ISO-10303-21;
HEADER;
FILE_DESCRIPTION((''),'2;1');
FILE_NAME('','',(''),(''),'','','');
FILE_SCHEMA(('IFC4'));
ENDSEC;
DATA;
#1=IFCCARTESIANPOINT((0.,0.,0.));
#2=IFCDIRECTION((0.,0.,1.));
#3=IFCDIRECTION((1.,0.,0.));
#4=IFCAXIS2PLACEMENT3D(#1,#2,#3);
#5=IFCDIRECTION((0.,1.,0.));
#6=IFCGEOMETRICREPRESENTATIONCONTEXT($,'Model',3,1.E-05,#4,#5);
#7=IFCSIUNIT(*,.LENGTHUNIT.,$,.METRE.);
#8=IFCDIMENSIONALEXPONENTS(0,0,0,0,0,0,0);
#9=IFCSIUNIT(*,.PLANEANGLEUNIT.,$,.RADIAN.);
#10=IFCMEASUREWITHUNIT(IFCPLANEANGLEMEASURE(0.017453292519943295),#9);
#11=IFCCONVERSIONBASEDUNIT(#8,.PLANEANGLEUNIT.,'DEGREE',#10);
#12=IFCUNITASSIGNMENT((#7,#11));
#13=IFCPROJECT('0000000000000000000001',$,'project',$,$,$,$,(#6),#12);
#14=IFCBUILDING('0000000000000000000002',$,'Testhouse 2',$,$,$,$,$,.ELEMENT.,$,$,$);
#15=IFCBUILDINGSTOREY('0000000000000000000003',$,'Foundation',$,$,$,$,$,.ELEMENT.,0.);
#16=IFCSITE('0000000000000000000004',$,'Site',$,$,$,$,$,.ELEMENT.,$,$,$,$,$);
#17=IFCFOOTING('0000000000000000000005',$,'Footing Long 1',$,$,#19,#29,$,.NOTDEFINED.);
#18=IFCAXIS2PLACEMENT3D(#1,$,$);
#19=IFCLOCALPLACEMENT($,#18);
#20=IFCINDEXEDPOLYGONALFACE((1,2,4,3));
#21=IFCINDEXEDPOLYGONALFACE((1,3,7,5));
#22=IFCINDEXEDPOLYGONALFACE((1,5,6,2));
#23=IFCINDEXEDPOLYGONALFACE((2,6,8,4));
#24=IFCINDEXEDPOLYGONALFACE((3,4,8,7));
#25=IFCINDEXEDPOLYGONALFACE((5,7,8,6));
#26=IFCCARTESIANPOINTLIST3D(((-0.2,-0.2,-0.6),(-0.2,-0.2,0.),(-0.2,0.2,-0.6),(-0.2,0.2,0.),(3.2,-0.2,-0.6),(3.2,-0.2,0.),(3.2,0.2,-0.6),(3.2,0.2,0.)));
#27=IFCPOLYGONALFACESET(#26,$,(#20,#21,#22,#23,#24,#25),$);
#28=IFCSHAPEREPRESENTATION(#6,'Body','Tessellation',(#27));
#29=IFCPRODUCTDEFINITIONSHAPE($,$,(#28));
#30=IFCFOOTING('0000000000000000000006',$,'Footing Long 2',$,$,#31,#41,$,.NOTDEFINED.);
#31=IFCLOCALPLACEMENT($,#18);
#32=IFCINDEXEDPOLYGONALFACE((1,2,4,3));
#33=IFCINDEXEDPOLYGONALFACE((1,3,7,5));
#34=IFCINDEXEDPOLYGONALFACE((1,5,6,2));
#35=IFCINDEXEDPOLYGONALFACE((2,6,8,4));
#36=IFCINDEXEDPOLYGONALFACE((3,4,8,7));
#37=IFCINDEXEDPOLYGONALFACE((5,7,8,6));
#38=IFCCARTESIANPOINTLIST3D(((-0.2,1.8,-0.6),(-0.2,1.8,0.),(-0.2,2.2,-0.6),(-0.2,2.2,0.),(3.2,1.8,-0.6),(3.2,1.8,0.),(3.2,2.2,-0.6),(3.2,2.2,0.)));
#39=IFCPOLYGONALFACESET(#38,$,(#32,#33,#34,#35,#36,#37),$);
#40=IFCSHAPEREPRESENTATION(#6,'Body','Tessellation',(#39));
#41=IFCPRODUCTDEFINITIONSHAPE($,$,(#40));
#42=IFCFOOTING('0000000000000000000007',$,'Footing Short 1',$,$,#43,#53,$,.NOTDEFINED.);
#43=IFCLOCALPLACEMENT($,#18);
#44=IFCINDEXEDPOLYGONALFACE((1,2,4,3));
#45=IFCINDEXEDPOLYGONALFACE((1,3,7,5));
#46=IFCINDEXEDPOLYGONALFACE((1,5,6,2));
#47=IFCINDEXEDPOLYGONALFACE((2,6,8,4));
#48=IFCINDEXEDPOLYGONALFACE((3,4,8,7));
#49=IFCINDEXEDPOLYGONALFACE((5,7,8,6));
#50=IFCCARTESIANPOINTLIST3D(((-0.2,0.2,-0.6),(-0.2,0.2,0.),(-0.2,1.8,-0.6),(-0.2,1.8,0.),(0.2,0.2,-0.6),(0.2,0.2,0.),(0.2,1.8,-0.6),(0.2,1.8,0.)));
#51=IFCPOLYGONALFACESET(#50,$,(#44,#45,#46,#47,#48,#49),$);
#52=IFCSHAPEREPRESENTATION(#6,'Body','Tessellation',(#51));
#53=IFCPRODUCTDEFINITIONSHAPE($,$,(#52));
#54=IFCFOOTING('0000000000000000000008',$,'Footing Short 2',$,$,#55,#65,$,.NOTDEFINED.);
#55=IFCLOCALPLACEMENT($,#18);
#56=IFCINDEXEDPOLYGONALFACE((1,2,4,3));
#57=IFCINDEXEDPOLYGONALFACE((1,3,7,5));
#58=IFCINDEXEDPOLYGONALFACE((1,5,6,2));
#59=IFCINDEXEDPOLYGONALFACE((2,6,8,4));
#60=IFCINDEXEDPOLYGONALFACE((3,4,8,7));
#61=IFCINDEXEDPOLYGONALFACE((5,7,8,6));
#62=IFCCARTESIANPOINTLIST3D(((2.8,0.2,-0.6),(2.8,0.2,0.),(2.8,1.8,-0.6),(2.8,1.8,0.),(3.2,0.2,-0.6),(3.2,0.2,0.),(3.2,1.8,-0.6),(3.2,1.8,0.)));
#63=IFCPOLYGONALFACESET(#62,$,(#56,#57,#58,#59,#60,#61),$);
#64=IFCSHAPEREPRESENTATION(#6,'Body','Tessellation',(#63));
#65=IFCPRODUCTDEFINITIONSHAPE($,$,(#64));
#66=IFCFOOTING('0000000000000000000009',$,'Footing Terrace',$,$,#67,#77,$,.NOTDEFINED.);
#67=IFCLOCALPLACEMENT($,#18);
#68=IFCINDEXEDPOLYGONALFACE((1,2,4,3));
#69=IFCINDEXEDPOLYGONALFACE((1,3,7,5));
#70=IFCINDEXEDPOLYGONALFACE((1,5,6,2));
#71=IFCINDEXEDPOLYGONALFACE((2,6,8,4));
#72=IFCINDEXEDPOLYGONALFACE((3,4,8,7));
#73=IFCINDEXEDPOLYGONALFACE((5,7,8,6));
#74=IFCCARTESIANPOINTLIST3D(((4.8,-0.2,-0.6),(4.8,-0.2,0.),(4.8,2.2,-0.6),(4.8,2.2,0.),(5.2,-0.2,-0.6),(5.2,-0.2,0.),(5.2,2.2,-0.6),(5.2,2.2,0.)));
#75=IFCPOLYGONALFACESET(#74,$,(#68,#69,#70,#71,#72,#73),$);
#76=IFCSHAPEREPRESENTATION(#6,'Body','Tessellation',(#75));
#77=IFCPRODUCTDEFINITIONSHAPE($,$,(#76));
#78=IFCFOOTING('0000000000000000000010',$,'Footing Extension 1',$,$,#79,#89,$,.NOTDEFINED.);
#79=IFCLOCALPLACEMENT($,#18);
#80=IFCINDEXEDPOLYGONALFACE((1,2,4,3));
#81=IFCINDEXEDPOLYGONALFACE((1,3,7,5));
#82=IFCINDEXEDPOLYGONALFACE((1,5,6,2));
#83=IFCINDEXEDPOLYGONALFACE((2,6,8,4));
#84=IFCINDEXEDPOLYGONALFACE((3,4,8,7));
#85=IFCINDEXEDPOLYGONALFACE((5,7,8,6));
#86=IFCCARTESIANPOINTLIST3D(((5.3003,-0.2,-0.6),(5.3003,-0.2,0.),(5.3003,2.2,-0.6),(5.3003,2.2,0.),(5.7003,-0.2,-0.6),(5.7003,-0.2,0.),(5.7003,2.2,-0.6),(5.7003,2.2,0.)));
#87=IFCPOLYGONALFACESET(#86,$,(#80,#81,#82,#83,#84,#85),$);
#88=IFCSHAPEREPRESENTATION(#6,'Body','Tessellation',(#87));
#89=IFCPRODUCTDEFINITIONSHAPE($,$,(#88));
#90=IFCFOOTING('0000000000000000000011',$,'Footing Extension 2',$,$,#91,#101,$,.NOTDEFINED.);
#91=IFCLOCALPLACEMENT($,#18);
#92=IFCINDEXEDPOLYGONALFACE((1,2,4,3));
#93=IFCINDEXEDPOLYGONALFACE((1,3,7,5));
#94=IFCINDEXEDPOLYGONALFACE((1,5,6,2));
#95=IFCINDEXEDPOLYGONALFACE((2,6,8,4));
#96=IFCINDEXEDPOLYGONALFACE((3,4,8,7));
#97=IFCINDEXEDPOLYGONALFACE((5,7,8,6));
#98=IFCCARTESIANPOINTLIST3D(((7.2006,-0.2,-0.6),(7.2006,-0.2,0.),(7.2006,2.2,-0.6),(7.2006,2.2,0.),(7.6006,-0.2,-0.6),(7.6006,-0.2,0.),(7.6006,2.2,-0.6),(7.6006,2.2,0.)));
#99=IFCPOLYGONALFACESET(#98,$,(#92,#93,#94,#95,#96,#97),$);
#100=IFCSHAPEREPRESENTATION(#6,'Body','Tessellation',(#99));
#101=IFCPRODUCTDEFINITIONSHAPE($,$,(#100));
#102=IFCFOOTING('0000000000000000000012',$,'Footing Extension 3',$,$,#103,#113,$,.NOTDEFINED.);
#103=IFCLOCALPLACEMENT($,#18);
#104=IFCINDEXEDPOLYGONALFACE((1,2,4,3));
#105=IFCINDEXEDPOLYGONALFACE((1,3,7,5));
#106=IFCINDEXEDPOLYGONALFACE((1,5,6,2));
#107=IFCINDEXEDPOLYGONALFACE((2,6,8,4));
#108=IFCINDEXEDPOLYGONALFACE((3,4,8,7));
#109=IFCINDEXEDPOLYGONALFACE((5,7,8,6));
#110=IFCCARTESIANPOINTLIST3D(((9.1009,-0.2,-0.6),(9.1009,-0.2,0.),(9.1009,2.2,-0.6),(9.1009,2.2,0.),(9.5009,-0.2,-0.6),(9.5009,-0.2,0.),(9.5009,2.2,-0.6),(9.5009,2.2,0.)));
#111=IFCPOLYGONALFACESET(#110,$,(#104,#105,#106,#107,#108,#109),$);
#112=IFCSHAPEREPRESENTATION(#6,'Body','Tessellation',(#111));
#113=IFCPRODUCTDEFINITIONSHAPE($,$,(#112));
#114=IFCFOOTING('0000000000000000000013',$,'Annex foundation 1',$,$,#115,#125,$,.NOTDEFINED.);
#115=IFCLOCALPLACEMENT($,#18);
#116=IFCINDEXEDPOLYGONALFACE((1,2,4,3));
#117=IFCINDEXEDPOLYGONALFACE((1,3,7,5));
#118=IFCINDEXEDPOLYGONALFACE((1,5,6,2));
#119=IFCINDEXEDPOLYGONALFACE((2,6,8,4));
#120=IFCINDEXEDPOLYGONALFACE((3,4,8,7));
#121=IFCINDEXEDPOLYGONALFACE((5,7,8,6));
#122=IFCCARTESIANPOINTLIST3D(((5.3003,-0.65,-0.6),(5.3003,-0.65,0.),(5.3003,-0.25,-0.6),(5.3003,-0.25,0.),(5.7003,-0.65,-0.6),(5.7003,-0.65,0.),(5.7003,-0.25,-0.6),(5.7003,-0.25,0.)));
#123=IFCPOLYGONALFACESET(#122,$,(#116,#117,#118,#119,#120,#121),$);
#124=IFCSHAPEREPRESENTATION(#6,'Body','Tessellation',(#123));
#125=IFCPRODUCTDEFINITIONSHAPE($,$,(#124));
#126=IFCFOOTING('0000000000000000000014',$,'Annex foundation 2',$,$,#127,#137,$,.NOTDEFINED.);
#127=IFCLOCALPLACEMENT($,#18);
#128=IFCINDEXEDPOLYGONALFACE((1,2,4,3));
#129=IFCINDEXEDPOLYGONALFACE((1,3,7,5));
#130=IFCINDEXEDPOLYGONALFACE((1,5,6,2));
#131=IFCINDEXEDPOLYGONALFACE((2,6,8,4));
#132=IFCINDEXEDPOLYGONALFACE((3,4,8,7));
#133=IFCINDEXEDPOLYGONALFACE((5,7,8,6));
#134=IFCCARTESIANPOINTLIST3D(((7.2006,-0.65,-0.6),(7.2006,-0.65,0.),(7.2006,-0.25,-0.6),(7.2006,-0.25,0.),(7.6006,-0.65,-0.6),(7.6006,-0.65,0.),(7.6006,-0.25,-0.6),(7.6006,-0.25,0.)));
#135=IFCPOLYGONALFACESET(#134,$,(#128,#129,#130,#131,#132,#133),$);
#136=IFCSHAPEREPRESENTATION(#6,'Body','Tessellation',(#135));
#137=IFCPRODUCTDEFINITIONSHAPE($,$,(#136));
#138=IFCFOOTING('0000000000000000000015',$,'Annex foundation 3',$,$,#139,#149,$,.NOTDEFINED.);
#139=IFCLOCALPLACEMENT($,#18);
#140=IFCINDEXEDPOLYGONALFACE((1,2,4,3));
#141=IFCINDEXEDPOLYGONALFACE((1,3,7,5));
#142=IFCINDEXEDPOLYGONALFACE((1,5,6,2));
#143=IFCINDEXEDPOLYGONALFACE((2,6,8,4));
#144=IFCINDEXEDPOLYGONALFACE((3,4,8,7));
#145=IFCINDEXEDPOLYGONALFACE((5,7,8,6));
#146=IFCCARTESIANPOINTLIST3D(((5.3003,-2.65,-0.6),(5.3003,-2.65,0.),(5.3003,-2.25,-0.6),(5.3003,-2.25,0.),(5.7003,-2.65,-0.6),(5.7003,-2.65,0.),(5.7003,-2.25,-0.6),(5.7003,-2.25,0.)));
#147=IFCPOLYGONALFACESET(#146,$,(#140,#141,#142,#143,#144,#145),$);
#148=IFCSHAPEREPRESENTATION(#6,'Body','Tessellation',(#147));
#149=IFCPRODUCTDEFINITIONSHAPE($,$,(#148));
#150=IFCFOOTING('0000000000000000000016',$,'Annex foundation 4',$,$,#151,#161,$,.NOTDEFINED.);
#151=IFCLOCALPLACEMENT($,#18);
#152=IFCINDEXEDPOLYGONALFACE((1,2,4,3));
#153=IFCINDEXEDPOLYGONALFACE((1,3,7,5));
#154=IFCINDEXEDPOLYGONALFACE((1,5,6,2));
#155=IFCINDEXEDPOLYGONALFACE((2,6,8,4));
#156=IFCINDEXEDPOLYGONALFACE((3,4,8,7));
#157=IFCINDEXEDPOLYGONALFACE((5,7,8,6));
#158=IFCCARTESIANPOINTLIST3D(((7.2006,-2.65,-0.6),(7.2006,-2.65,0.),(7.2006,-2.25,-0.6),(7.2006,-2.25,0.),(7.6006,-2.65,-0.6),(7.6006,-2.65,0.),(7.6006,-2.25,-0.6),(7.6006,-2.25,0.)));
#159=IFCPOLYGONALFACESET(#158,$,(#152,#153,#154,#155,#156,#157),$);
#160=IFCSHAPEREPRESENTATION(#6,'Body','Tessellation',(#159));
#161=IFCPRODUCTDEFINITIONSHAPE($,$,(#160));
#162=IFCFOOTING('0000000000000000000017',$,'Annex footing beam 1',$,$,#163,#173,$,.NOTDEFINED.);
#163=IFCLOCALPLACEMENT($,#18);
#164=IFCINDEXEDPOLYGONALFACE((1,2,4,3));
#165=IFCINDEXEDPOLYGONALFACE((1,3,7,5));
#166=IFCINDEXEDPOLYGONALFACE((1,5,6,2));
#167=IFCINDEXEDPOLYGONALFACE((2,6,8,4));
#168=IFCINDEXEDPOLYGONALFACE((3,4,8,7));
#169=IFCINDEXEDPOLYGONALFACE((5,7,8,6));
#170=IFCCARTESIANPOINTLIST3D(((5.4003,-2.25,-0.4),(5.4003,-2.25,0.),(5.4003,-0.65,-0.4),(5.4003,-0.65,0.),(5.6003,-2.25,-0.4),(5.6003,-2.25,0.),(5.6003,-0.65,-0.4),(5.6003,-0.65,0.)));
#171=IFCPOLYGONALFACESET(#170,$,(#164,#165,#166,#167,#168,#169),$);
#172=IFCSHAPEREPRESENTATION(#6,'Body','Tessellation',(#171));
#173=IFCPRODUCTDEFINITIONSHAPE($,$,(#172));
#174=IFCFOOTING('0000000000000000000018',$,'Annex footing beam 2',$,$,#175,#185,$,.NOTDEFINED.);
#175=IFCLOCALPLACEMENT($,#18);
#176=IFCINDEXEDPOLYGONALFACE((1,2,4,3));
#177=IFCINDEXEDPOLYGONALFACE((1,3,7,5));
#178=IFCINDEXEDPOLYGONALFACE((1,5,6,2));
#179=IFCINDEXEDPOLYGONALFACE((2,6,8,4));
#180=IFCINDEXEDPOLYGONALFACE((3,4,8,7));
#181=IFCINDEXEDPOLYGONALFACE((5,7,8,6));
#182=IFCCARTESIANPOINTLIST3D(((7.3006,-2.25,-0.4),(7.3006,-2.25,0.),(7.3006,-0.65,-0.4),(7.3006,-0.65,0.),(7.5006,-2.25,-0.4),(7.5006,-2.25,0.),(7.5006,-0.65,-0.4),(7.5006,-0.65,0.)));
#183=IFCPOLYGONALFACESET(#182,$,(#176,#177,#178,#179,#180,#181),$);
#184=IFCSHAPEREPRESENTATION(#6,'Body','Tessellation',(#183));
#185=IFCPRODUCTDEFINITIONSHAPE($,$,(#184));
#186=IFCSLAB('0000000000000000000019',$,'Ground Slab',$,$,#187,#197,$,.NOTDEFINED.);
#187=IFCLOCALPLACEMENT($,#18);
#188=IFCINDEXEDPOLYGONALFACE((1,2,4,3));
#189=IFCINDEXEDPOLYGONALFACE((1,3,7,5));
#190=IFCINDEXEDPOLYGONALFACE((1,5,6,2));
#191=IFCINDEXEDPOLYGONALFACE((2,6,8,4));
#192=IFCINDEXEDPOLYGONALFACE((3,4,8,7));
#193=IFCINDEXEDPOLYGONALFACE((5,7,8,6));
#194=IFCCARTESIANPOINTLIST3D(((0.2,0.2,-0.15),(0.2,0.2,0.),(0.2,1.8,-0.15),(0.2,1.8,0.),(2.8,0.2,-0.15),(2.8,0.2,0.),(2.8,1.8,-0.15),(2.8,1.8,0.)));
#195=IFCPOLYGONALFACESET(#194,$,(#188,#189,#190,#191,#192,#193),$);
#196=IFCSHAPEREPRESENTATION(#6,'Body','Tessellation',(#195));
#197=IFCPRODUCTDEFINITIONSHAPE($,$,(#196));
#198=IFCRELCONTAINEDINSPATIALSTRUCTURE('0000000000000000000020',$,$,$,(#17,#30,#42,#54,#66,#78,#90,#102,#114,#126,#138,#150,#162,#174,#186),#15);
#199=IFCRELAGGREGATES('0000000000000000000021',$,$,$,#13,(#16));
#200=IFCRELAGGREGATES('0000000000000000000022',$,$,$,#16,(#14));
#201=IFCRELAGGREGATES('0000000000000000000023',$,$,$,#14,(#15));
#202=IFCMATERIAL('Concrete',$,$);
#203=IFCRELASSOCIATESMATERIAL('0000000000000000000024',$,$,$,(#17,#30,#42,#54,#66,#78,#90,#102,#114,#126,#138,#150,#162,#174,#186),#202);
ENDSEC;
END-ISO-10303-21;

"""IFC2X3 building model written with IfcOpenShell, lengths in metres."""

from ifc_helpers import new_model, entity, si_unit, converted_unit, direction, frame, origin_with_axes, place, context, project, spatial, polyline, outline, extrude, material, element, save


model = new_model("IFC2X3")

# Units and contexts
model_context = context("Model", 3, precision=1e-05, world=origin_with_axes(), true_north=direction((0.0, 1.0, 0.0)))
ifc_project = project(units=[si_unit("LENGTHUNIT", "METRE"), converted_unit("PLANEANGLEUNIT", "DEGREE", entity("IfcPlaneAngleMeasure", 0.017453292519943295), si_unit("PLANEANGLEUNIT", "RADIAN"), dimensions=[0, 0, 0, 0, 0, 0, 0])], contexts=[model_context])

# Site, building, storey
site = spatial("IfcSite", under=ifc_project, Name="Site", CompositionType="ELEMENT")
building = spatial("IfcBuilding", under=site, Name="Testhouse 2", CompositionType="ELEMENT")
storey = spatial("IfcBuildingStorey", under=building, Name="Foundation", CompositionType="ELEMENT", Elevation=0.0)

# Footings
ifc_material = material(Name="Concrete")
footing_1_placement = place(None, origin_with_axes())
element("IfcFooting", 1, at=footing_1_placement, inside=storey, material=ifc_material, Name="Footing Long 1", PredefinedType="NOTDEFINED", context=model_context, shape_type="SweptSolid", body=[
    extrude(outline(polyline([(-0.3, -0.2), (0.3, -0.2), (0.3, 0.2), (-0.3, 0.2), (-0.3, -0.2)])), frame((-0.2, 0.0, -0.3), z_axis=(1.0, 0.0, 0.0), x_axis=(0.0, 0.0, -1.0)), (0.0, 0.0, 1.0), 3.4),
])
footing_2_placement = place(None, origin_with_axes())
element("IfcFooting", 2, at=footing_2_placement, inside=storey, material=ifc_material, Name="Footing Long 2", PredefinedType="NOTDEFINED", context=model_context, shape_type="SweptSolid", body=[
    extrude(outline(polyline([(-0.3, -0.2), (0.3, -0.2), (0.3, 0.2), (-0.3, 0.2), (-0.3, -0.2)])), frame((-0.2, 2.0, -0.3), z_axis=(1.0, 0.0, 0.0), x_axis=(0.0, 0.0, -1.0)), (0.0, 0.0, 1.0), 3.4),
])
footing_3_placement = place(None, origin_with_axes())
element("IfcFooting", 3, at=footing_3_placement, inside=storey, material=ifc_material, Name="Footing Short 1", PredefinedType="NOTDEFINED", context=model_context, shape_type="SweptSolid", body=[
    extrude(outline(polyline([(-0.3, -0.2), (0.3, -0.2), (0.3, 0.2), (-0.3, 0.2), (-0.3, -0.2)])), frame((0.0, 0.2, -0.3), z_axis=(0.0, 1.0, 0.0), x_axis=(0.0, 0.0, -1.0)), (0.0, 0.0, 1.0), 1.6),
])
footing_4_placement = place(None, origin_with_axes())
element("IfcFooting", 4, at=footing_4_placement, inside=storey, material=ifc_material, Name="Footing Short 2", PredefinedType="NOTDEFINED", context=model_context, shape_type="SweptSolid", body=[
    extrude(outline(polyline([(-0.3, -0.2), (0.3, -0.2), (0.3, 0.2), (-0.3, 0.2), (-0.3, -0.2)])), frame((3.0, 0.2, -0.3), z_axis=(0.0, 1.0, 0.0), x_axis=(0.0, 0.0, -1.0)), (0.0, 0.0, 1.0), 1.6),
])
footing_5_placement = place(None, origin_with_axes())
element("IfcFooting", 5, at=footing_5_placement, inside=storey, material=ifc_material, Name="Footing Terrace", PredefinedType="NOTDEFINED", context=model_context, shape_type="SweptSolid", body=[
    extrude(outline(polyline([(-0.3, -0.2), (0.3, -0.2), (0.3, 0.2), (-0.3, 0.2), (-0.3, -0.2)])), frame((5.0, -0.2, -0.3), z_axis=(0.0, 1.0, 0.0), x_axis=(0.0, 0.0, -1.0)), (0.0, 0.0, 1.0), 2.4),
])
footing_6_placement = place(None, origin_with_axes())
element("IfcFooting", 6, at=footing_6_placement, inside=storey, material=ifc_material, Name="Footing Extension 1", PredefinedType="NOTDEFINED", context=model_context, shape_type="SweptSolid", body=[
    extrude(outline(polyline([(-0.3, -0.2), (0.3, -0.2), (0.3, 0.2), (-0.3, 0.2), (-0.3, -0.2)])), frame((5.5003, -0.2, -0.3), z_axis=(0.0, 1.0, 0.0), x_axis=(0.0, 0.0, -1.0)), (0.0, 0.0, 1.0), 2.4),
])
footing_7_placement = place(None, origin_with_axes())
element("IfcFooting", 7, at=footing_7_placement, inside=storey, material=ifc_material, Name="Footing Extension 2", PredefinedType="NOTDEFINED", context=model_context, shape_type="SweptSolid", body=[
    extrude(outline(polyline([(-0.3, -0.2), (0.3, -0.2), (0.3, 0.2), (-0.3, 0.2), (-0.3, -0.2)])), frame((7.4006, -0.2, -0.3), z_axis=(0.0, 1.0, 0.0), x_axis=(0.0, 0.0, -1.0)), (0.0, 0.0, 1.0), 2.4),
])
footing_8_placement = place(None, origin_with_axes())
element("IfcFooting", 8, at=footing_8_placement, inside=storey, material=ifc_material, Name="Footing Extension 3", PredefinedType="NOTDEFINED", context=model_context, shape_type="SweptSolid", body=[
    extrude(outline(polyline([(-0.3, -0.2), (0.3, -0.2), (0.3, 0.2), (-0.3, 0.2), (-0.3, -0.2)])), frame((9.3009, -0.2, -0.3), z_axis=(0.0, 1.0, 0.0), x_axis=(0.0, 0.0, -1.0)), (0.0, 0.0, 1.0), 2.4),
])
footing_9_placement = place(None, origin_with_axes())
element("IfcFooting", 9, at=footing_9_placement, inside=storey, material=ifc_material, Name="Annex foundation 1", PredefinedType="NOTDEFINED", context=model_context, shape_type="SweptSolid", body=[
    extrude(outline(polyline([(-0.2, -0.2), (0.2, -0.2), (0.2, 0.2), (-0.2, 0.2), (-0.2, -0.2)])), frame((5.5003, -0.45, -0.6), z_axis=(0.0, 0.0, 1.0), x_axis=(1.0, 0.0, 0.0)), (0.0, 0.0, 1.0), 0.6),
])
footing_10_placement = place(None, origin_with_axes())
element("IfcFooting", 10, at=footing_10_placement, inside=storey, material=ifc_material, Name="Annex foundation 2", PredefinedType="NOTDEFINED", context=model_context, shape_type="SweptSolid", body=[
    extrude(outline(polyline([(-0.2, -0.2), (0.2, -0.2), (0.2, 0.2), (-0.2, 0.2), (-0.2, -0.2)])), frame((7.4006, -0.45, -0.6), z_axis=(0.0, 0.0, 1.0), x_axis=(1.0, 0.0, 0.0)), (0.0, 0.0, 1.0), 0.6),
])
footing_11_placement = place(None, origin_with_axes())
element("IfcFooting", 11, at=footing_11_placement, inside=storey, material=ifc_material, Name="Annex foundation 3", PredefinedType="NOTDEFINED", context=model_context, shape_type="SweptSolid", body=[
    extrude(outline(polyline([(-0.2, -0.2), (0.2, -0.2), (0.2, 0.2), (-0.2, 0.2), (-0.2, -0.2)])), frame((5.5003, -2.45, -0.6), z_axis=(0.0, 0.0, 1.0), x_axis=(1.0, 0.0, 0.0)), (0.0, 0.0, 1.0), 0.6),
])
footing_12_placement = place(None, origin_with_axes())
element("IfcFooting", 12, at=footing_12_placement, inside=storey, material=ifc_material, Name="Annex foundation 4", PredefinedType="NOTDEFINED", context=model_context, shape_type="SweptSolid", body=[
    extrude(outline(polyline([(-0.2, -0.2), (0.2, -0.2), (0.2, 0.2), (-0.2, 0.2), (-0.2, -0.2)])), frame((7.4006, -2.45, -0.6), z_axis=(0.0, 0.0, 1.0), x_axis=(1.0, 0.0, 0.0)), (0.0, 0.0, 1.0), 0.6),
])
footing_13_placement = place(None, origin_with_axes())
element("IfcFooting", 13, at=footing_13_placement, inside=storey, material=ifc_material, Name="Annex footing beam 1", PredefinedType="NOTDEFINED", context=model_context, shape_type="SweptSolid", body=[
    extrude(outline(polyline([(-0.2, -0.1), (0.2, -0.1), (0.2, 0.1), (-0.2, 0.1), (-0.2, -0.1)])), frame((5.5003, -2.25, -0.2), z_axis=(0.0, 1.0, 0.0), x_axis=(0.0, 0.0, -1.0)), (0.0, 0.0, 1.0), 1.6),
])
footing_14_placement = place(None, origin_with_axes())
element("IfcFooting", 14, at=footing_14_placement, inside=storey, material=ifc_material, Name="Annex footing beam 2", PredefinedType="NOTDEFINED", context=model_context, shape_type="SweptSolid", body=[
    extrude(outline(polyline([(-0.2, -0.1), (0.2, -0.1), (0.2, 0.1), (-0.2, 0.1), (-0.2, -0.1)])), frame((7.4006, -2.25, -0.2), z_axis=(0.0, 1.0, 0.0), x_axis=(0.0, 0.0, -1.0)), (0.0, 0.0, 1.0), 1.6),
])

# Slab
slab_1_placement = place(None, origin_with_axes())
element("IfcSlab", 15, at=slab_1_placement, inside=storey, material=ifc_material, Name="Ground Slab", PredefinedType="NOTDEFINED", context=model_context, shape_type="SweptSolid", body=[
    extrude(outline(polyline([(0.0, 0.0), (2.6, 0.0), (2.6, -1.6), (0.0, -1.6), (0.0, 0.0)])), frame((0.2, 1.8, -0.15), z_axis=(0.0, 0.0, 1.0), x_axis=(1.0, 0.0, 0.0)), (0.0, 0.0, 1.0), 0.15),
])

save(model, "model.ifc")
